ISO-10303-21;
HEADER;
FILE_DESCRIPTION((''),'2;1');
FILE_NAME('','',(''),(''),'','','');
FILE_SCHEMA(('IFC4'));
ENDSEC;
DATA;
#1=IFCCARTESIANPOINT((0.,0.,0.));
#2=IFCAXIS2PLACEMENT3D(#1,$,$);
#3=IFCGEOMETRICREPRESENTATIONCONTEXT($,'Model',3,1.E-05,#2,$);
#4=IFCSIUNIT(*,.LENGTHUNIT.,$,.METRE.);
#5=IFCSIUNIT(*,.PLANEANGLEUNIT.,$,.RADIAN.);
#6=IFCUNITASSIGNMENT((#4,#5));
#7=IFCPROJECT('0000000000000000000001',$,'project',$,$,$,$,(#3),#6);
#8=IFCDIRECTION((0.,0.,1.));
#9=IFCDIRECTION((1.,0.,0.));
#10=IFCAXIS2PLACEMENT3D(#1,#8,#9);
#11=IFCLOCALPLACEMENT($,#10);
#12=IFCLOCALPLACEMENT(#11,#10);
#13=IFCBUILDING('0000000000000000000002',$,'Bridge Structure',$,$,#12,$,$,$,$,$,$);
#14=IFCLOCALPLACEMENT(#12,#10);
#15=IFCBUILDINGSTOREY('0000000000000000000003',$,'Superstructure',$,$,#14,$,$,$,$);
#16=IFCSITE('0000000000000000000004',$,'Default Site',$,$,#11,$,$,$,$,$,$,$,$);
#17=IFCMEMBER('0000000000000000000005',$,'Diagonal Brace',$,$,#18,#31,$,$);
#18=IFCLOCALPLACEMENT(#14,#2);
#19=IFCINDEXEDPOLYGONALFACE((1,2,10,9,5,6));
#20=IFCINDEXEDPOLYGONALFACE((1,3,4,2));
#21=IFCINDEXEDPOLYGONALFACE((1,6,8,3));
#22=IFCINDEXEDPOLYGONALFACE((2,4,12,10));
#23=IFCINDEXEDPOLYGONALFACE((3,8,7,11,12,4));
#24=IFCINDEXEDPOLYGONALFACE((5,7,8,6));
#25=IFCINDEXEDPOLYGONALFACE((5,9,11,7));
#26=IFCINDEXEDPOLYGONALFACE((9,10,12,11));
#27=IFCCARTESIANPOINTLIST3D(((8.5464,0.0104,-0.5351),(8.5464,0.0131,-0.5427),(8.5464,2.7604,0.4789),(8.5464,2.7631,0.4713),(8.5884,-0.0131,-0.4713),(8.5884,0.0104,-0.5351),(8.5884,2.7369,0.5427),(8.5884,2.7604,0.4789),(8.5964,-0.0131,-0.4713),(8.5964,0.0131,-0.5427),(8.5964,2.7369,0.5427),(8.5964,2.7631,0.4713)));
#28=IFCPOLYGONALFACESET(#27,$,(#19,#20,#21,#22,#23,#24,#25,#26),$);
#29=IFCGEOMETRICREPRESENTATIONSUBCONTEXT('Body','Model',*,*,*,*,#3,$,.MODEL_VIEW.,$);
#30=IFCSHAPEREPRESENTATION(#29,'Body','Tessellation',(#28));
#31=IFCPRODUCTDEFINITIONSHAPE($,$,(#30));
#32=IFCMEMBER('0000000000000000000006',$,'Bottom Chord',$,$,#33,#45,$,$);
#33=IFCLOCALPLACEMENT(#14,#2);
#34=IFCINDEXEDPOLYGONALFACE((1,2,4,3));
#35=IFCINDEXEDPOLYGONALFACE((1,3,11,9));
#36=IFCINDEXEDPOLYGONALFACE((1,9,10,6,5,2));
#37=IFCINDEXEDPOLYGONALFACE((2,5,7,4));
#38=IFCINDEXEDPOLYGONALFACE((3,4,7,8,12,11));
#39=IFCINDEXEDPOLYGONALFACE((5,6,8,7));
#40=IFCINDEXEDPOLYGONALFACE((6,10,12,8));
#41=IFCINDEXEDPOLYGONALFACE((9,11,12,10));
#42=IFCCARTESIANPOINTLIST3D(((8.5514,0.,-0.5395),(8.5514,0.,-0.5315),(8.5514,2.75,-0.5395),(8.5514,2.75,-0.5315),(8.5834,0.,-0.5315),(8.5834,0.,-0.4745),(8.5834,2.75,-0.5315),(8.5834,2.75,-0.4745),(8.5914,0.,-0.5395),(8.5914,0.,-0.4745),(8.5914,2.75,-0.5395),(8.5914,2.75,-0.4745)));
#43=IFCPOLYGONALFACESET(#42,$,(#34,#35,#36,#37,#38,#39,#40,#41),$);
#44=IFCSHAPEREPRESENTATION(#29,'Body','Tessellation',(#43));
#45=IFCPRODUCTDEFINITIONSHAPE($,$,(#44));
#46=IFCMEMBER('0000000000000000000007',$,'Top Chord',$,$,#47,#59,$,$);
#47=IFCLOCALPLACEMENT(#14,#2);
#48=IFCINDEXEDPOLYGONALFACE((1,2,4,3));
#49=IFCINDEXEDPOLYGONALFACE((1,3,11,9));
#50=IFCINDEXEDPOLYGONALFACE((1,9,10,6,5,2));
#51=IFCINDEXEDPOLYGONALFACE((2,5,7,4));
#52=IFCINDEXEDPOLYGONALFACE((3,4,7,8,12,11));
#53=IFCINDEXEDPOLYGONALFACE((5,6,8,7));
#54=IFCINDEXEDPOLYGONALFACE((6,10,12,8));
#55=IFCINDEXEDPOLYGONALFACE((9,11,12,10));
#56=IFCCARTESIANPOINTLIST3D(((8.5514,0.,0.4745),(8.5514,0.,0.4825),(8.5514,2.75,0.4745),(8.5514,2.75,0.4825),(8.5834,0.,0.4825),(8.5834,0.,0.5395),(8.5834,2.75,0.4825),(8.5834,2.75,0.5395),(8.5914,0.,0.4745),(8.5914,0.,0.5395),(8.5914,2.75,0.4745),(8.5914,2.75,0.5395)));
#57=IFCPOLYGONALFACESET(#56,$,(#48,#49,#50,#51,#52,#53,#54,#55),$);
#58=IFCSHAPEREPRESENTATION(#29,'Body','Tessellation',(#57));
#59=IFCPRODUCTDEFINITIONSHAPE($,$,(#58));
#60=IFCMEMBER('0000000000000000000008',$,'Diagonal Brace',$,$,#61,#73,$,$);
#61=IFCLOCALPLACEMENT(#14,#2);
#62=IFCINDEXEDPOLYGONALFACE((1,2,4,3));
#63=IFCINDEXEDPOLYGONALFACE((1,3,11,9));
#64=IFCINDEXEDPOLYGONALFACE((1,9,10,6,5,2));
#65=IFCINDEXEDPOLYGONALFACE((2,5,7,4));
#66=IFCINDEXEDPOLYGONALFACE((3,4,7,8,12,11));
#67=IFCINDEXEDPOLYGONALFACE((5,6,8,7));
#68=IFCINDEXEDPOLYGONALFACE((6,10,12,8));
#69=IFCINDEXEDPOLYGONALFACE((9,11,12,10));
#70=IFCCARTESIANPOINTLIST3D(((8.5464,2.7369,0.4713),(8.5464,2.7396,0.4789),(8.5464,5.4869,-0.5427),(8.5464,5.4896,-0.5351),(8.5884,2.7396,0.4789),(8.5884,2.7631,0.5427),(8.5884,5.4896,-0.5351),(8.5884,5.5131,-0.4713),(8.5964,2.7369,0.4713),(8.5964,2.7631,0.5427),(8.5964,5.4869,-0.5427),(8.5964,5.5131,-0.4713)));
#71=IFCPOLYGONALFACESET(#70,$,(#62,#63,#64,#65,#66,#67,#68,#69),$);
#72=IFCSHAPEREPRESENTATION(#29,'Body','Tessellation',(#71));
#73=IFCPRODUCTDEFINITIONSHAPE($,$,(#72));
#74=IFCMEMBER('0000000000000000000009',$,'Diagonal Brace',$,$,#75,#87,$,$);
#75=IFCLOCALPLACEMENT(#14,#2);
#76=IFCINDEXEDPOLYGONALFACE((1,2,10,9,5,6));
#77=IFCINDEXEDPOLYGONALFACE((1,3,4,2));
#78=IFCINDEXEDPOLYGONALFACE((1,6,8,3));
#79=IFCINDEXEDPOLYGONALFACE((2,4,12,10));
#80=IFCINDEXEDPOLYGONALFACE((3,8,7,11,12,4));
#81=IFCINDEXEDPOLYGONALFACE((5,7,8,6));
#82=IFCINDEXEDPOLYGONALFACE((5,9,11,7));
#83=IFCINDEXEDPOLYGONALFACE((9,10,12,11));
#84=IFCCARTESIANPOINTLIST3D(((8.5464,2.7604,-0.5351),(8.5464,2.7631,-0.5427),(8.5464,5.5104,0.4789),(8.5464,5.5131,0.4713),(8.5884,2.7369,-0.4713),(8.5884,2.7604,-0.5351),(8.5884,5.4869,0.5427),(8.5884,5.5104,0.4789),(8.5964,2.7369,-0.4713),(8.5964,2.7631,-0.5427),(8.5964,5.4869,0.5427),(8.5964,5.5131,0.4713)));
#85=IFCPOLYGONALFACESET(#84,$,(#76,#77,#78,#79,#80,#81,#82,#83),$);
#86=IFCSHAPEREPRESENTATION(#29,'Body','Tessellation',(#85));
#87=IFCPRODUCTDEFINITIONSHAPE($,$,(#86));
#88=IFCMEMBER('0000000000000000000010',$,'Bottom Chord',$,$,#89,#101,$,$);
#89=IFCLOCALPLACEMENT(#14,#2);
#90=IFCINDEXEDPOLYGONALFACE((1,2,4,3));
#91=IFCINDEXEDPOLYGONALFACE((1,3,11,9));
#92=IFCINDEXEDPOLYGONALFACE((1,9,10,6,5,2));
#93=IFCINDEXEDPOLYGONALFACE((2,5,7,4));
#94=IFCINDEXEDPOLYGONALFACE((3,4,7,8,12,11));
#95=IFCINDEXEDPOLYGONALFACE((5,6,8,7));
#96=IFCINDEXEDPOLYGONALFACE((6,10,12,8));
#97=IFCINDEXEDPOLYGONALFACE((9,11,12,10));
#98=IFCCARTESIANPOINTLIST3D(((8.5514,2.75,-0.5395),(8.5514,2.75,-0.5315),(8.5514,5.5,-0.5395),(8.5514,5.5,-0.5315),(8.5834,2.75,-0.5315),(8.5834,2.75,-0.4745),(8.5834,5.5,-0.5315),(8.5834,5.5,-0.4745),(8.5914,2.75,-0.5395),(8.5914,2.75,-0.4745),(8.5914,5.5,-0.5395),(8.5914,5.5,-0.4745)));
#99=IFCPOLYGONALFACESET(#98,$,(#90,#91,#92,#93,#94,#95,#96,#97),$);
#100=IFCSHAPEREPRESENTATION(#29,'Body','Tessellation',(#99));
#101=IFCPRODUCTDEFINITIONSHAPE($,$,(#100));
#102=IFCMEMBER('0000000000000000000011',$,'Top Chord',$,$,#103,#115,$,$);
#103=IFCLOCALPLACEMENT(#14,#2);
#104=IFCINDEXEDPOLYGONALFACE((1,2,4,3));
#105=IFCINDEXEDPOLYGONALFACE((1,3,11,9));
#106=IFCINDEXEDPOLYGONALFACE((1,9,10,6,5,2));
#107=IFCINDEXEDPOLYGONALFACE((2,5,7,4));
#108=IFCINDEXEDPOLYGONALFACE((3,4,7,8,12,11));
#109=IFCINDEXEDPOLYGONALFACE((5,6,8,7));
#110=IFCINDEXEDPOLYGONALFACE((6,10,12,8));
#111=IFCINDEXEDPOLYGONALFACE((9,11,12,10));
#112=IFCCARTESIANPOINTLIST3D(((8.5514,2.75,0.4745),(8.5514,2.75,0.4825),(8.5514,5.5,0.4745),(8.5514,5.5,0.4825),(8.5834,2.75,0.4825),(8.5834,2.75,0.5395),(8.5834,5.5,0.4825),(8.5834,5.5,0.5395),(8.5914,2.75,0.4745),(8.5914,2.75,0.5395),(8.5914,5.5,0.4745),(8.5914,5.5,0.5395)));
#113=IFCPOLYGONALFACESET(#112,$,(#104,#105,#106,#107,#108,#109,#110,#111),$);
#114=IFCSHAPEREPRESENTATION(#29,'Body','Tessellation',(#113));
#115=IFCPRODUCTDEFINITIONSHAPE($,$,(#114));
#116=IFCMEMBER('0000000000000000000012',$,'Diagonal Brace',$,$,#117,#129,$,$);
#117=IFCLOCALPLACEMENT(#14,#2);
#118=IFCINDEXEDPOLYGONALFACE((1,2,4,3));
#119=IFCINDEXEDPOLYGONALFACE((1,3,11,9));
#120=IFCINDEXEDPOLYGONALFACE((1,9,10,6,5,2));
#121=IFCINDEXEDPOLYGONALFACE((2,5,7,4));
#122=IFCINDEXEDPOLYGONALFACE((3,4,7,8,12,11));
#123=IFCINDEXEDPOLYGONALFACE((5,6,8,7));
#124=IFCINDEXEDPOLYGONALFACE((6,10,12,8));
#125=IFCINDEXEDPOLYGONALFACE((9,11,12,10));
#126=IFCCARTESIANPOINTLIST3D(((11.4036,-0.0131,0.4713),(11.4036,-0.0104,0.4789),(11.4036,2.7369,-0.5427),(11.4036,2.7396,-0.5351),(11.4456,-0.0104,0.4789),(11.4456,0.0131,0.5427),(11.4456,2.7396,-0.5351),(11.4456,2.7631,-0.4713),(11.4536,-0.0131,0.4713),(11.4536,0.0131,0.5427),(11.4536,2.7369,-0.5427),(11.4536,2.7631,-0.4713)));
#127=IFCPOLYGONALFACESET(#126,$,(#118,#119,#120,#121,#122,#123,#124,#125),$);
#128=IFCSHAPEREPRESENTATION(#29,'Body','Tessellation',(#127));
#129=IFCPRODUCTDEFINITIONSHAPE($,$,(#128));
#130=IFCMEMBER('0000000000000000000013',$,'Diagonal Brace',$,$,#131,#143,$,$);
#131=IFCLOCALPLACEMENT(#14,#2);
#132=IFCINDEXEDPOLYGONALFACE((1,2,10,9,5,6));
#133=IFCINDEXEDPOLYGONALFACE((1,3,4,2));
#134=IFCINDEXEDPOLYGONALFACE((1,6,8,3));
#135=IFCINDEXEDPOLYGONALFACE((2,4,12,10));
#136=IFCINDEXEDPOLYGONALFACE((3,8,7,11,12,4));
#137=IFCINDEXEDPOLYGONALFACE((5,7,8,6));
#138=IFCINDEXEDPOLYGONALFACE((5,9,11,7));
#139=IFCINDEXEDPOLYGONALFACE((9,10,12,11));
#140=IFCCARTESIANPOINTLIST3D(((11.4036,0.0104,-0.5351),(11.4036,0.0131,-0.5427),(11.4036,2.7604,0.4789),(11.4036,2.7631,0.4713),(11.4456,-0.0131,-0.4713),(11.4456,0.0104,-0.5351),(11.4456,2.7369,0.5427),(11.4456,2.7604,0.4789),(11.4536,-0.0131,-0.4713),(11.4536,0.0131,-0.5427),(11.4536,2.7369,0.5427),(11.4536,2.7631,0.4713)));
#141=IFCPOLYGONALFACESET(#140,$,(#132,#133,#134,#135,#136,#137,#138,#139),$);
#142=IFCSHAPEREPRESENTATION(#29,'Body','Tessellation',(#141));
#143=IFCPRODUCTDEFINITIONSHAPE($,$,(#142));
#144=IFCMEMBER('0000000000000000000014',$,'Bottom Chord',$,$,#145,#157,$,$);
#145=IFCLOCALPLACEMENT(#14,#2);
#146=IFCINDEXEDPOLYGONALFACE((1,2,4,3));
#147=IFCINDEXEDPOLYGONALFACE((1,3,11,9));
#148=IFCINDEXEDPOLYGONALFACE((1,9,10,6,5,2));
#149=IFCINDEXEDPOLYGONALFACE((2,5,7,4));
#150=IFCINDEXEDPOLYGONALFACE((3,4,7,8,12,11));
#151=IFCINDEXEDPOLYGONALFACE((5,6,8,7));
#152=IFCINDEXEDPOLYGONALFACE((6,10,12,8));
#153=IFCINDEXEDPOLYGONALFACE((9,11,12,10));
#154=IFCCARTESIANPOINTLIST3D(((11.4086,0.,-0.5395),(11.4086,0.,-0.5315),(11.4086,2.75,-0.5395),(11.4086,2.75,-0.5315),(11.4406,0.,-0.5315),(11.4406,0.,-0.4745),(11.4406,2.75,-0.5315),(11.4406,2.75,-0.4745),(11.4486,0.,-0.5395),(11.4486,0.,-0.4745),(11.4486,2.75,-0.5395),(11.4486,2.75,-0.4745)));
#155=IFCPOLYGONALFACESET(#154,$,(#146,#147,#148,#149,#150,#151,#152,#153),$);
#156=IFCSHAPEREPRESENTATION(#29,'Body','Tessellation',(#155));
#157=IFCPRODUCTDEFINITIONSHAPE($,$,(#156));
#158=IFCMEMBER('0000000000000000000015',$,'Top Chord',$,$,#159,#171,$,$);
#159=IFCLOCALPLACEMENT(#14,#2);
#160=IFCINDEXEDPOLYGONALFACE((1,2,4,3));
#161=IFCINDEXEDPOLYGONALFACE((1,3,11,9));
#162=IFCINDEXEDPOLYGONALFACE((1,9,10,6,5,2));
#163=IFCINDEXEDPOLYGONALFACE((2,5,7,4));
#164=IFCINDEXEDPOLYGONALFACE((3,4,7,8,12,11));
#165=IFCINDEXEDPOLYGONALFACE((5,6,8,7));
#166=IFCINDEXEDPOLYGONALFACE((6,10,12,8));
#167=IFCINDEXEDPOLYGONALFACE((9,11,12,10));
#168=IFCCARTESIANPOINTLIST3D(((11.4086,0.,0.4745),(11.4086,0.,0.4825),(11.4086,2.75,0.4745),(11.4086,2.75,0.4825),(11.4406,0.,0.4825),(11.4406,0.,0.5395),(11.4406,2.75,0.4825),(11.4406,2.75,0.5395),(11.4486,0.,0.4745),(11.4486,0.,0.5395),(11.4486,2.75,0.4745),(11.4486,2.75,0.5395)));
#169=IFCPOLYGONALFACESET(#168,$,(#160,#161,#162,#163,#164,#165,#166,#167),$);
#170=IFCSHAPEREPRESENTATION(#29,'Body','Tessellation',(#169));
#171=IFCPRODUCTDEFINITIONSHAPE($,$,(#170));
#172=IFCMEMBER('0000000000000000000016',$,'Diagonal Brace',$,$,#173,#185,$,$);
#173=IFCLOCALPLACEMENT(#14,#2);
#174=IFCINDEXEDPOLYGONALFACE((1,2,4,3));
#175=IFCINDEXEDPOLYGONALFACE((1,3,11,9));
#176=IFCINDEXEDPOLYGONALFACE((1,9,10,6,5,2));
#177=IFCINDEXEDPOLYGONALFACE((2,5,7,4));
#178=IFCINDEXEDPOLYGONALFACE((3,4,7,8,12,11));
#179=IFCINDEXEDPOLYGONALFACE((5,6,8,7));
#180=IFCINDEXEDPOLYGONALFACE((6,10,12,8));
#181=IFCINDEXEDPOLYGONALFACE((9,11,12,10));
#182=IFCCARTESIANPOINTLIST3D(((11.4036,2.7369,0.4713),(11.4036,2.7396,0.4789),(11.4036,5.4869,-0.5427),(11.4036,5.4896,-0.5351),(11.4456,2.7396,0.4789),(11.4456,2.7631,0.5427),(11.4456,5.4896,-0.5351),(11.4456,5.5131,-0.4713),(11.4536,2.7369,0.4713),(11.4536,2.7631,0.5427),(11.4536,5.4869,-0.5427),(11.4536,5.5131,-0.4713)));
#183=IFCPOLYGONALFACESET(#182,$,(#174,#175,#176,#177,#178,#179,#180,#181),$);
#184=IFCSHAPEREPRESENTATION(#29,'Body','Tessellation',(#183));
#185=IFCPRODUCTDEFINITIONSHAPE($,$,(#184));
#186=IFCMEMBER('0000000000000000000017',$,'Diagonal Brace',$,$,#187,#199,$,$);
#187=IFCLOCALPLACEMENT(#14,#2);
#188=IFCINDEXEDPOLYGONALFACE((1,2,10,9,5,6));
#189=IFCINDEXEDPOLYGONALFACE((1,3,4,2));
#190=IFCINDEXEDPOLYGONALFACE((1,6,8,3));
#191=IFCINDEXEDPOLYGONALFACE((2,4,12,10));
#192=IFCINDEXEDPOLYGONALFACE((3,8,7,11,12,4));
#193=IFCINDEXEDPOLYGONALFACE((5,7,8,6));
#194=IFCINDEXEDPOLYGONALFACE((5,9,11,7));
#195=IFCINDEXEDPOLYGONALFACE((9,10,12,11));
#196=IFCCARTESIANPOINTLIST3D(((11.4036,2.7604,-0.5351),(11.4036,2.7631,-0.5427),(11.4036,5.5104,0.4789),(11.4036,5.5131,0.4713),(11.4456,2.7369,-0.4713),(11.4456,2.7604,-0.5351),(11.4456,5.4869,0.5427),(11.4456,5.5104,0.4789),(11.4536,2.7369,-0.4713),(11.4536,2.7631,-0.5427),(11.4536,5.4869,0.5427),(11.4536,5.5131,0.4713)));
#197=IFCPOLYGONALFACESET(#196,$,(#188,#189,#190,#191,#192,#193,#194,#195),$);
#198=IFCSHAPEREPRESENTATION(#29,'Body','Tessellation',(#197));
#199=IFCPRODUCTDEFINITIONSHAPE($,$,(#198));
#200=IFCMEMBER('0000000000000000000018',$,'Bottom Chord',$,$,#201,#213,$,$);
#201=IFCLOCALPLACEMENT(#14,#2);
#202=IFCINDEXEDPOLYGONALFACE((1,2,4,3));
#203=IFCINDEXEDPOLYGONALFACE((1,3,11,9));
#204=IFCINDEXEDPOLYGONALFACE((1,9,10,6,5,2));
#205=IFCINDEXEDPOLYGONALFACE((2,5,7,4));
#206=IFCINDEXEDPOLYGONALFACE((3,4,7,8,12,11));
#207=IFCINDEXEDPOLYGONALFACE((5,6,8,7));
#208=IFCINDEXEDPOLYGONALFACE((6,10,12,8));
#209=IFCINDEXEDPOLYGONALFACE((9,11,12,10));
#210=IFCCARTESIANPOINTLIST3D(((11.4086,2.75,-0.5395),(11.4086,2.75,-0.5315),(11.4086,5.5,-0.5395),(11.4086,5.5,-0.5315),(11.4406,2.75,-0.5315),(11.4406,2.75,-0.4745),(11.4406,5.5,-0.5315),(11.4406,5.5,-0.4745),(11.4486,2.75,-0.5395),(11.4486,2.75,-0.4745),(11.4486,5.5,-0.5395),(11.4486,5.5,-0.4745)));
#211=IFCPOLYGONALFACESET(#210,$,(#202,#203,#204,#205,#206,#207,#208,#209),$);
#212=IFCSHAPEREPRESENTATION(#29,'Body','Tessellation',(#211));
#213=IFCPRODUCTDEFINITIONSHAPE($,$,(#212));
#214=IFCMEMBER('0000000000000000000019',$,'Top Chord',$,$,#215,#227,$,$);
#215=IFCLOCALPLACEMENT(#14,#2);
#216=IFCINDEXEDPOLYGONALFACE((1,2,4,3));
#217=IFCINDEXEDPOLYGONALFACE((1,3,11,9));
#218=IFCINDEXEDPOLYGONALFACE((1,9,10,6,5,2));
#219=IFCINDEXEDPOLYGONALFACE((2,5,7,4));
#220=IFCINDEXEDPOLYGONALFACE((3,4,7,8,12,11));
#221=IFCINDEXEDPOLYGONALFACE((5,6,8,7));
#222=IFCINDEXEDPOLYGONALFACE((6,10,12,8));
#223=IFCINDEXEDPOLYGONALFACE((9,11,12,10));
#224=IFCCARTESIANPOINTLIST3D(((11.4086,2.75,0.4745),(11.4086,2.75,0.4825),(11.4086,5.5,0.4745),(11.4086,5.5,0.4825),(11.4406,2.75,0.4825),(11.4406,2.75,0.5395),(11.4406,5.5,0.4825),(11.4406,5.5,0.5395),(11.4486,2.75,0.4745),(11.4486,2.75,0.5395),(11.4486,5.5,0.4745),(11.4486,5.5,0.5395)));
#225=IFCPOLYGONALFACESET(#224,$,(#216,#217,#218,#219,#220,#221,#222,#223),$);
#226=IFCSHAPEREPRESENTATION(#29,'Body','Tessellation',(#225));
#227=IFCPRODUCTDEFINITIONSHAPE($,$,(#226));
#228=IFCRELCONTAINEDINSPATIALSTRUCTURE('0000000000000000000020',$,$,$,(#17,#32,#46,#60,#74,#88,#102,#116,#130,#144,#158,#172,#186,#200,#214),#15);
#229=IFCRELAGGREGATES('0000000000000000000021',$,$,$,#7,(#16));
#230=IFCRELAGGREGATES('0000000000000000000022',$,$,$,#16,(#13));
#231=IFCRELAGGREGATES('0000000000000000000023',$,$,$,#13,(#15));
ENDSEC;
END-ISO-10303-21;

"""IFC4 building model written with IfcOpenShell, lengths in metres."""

from ifc_helpers import new_model, si_unit, frame, origin, origin_with_axes, origin_2d_with_axis, place, context, subcontext, project, spatial, l_section, extrude, element, save


model = new_model("IFC4")

# Units and contexts
model_context = context("Model", 3, precision=1e-05, world=origin())
body_context = subcontext(model_context, "Body", "Model", "MODEL_VIEW")
ifc_project = project(units=[si_unit("LENGTHUNIT", "METRE"), si_unit("PLANEANGLEUNIT", "RADIAN")], contexts=[model_context])

# Site, building, storey
site_placement = place(None, origin_with_axes())
site = spatial("IfcSite", under=ifc_project, at=site_placement, Name="Default Site")
building_placement = place(site_placement, origin_with_axes())
building = spatial("IfcBuilding", under=site, at=building_placement, Name="Bridge Structure")
storey_placement = place(building_placement, origin_with_axes())
storey = spatial("IfcBuildingStorey", under=building, at=storey_placement, Name="Superstructure")

# Members
member_1_placement = place(storey_placement, frame((8.5714, 0.0, -0.507), z_axis=(0.0, 0.93825, 0.345958), x_axis=(-1.0, 0.0, 0.0)))
element("IfcMember", 1, at=member_1_placement, inside=storey, Name="Diagonal Brace", context=body_context, shape_type="SweptSolid", body=[
    extrude(l_section(Depth=0.076, Width=0.05, Thickness=0.008, at=origin_2d_with_axis()), origin_with_axes(), (0.0, 0.0, 1.0), 2.931),
])
for number, where, z_axis, x_axis, name in (
    (2, (8.5714, 0.0, -0.507), (0.0, 1.0, 0.0), (-1.0, 0.0, 0.0), "Bottom Chord"),
    (3, (8.5714, 0.0, 0.507), (0.0, 1.0, 0.0), (-1.0, 0.0, 0.0), "Top Chord"),
):
    element("IfcMember", number, at=place(storey_placement, frame(where, z_axis=z_axis, x_axis=x_axis)), inside=storey, Name=name, context=body_context, shape_type="SweptSolid", body=[
        extrude(l_section(Depth=0.065, Width=0.04, Thickness=0.008, at=origin_2d_with_axis()), origin_with_axes(), (0.0, 0.0, 1.0), 2.75),
    ])
for number, where, z_axis, x_axis, name in (
    (4, (8.5714, 2.75, 0.507), (0.0, 0.93825, -0.345958), (-1.0, 0.0, 0.0), "Diagonal Brace"),
    (5, (8.5714, 2.75, -0.507), (0.0, 0.93825, 0.345958), (-1.0, 0.0, 0.0), "Diagonal Brace"),
):
    element("IfcMember", number, at=place(storey_placement, frame(where, z_axis=z_axis, x_axis=x_axis)), inside=storey, Name=name, context=body_context, shape_type="SweptSolid", body=[
        extrude(l_section(Depth=0.076, Width=0.05, Thickness=0.008, at=origin_2d_with_axis()), origin_with_axes(), (0.0, 0.0, 1.0), 2.931),
    ])
for number, where, z_axis, x_axis, name in (
    (6, (8.5714, 2.75, -0.507), (0.0, 1.0, 0.0), (-1.0, 0.0, 0.0), "Bottom Chord"),
    (7, (8.5714, 2.75, 0.507), (0.0, 1.0, 0.0), (-1.0, 0.0, 0.0), "Top Chord"),
):
    element("IfcMember", number, at=place(storey_placement, frame(where, z_axis=z_axis, x_axis=x_axis)), inside=storey, Name=name, context=body_context, shape_type="SweptSolid", body=[
        extrude(l_section(Depth=0.065, Width=0.04, Thickness=0.008, at=origin_2d_with_axis()), origin_with_axes(), (0.0, 0.0, 1.0), 2.75),
    ])
for number, where, z_axis, x_axis, name in (
    (8, (11.4286, 0.0, 0.507), (0.0, 0.93825, -0.345958), (-1.0, 0.0, 0.0), "Diagonal Brace"),
    (9, (11.4286, 0.0, -0.507), (0.0, 0.93825, 0.345958), (-1.0, 0.0, 0.0), "Diagonal Brace"),
):
    element("IfcMember", number, at=place(storey_placement, frame(where, z_axis=z_axis, x_axis=x_axis)), inside=storey, Name=name, context=body_context, shape_type="SweptSolid", body=[
        extrude(l_section(Depth=0.076, Width=0.05, Thickness=0.008, at=origin_2d_with_axis()), origin_with_axes(), (0.0, 0.0, 1.0), 2.931),
    ])
for number, where, z_axis, x_axis, name in (
    (10, (11.4286, 0.0, -0.507), (0.0, 1.0, 0.0), (-1.0, 0.0, 0.0), "Bottom Chord"),
    (11, (11.4286, 0.0, 0.507), (0.0, 1.0, 0.0), (-1.0, 0.0, 0.0), "Top Chord"),
):
    element("IfcMember", number, at=place(storey_placement, frame(where, z_axis=z_axis, x_axis=x_axis)), inside=storey, Name=name, context=body_context, shape_type="SweptSolid", body=[
        extrude(l_section(Depth=0.065, Width=0.04, Thickness=0.008, at=origin_2d_with_axis()), origin_with_axes(), (0.0, 0.0, 1.0), 2.75),
    ])
for number, where, z_axis, x_axis, name in (
    (12, (11.4286, 2.75, 0.507), (0.0, 0.93825, -0.345958), (-1.0, 0.0, 0.0), "Diagonal Brace"),
    (13, (11.4286, 2.75, -0.507), (0.0, 0.93825, 0.345958), (-1.0, 0.0, 0.0), "Diagonal Brace"),
):
    element("IfcMember", number, at=place(storey_placement, frame(where, z_axis=z_axis, x_axis=x_axis)), inside=storey, Name=name, context=body_context, shape_type="SweptSolid", body=[
        extrude(l_section(Depth=0.076, Width=0.05, Thickness=0.008, at=origin_2d_with_axis()), origin_with_axes(), (0.0, 0.0, 1.0), 2.931),
    ])
for number, where, z_axis, x_axis, name in (
    (14, (11.4286, 2.75, -0.507), (0.0, 1.0, 0.0), (-1.0, 0.0, 0.0), "Bottom Chord"),
    (15, (11.4286, 2.75, 0.507), (0.0, 1.0, 0.0), (-1.0, 0.0, 0.0), "Top Chord"),
):
    element("IfcMember", number, at=place(storey_placement, frame(where, z_axis=z_axis, x_axis=x_axis)), inside=storey, Name=name, context=body_context, shape_type="SweptSolid", body=[
        extrude(l_section(Depth=0.065, Width=0.04, Thickness=0.008, at=origin_2d_with_axis()), origin_with_axes(), (0.0, 0.0, 1.0), 2.75),
    ])

save(model, "model.ifc")
